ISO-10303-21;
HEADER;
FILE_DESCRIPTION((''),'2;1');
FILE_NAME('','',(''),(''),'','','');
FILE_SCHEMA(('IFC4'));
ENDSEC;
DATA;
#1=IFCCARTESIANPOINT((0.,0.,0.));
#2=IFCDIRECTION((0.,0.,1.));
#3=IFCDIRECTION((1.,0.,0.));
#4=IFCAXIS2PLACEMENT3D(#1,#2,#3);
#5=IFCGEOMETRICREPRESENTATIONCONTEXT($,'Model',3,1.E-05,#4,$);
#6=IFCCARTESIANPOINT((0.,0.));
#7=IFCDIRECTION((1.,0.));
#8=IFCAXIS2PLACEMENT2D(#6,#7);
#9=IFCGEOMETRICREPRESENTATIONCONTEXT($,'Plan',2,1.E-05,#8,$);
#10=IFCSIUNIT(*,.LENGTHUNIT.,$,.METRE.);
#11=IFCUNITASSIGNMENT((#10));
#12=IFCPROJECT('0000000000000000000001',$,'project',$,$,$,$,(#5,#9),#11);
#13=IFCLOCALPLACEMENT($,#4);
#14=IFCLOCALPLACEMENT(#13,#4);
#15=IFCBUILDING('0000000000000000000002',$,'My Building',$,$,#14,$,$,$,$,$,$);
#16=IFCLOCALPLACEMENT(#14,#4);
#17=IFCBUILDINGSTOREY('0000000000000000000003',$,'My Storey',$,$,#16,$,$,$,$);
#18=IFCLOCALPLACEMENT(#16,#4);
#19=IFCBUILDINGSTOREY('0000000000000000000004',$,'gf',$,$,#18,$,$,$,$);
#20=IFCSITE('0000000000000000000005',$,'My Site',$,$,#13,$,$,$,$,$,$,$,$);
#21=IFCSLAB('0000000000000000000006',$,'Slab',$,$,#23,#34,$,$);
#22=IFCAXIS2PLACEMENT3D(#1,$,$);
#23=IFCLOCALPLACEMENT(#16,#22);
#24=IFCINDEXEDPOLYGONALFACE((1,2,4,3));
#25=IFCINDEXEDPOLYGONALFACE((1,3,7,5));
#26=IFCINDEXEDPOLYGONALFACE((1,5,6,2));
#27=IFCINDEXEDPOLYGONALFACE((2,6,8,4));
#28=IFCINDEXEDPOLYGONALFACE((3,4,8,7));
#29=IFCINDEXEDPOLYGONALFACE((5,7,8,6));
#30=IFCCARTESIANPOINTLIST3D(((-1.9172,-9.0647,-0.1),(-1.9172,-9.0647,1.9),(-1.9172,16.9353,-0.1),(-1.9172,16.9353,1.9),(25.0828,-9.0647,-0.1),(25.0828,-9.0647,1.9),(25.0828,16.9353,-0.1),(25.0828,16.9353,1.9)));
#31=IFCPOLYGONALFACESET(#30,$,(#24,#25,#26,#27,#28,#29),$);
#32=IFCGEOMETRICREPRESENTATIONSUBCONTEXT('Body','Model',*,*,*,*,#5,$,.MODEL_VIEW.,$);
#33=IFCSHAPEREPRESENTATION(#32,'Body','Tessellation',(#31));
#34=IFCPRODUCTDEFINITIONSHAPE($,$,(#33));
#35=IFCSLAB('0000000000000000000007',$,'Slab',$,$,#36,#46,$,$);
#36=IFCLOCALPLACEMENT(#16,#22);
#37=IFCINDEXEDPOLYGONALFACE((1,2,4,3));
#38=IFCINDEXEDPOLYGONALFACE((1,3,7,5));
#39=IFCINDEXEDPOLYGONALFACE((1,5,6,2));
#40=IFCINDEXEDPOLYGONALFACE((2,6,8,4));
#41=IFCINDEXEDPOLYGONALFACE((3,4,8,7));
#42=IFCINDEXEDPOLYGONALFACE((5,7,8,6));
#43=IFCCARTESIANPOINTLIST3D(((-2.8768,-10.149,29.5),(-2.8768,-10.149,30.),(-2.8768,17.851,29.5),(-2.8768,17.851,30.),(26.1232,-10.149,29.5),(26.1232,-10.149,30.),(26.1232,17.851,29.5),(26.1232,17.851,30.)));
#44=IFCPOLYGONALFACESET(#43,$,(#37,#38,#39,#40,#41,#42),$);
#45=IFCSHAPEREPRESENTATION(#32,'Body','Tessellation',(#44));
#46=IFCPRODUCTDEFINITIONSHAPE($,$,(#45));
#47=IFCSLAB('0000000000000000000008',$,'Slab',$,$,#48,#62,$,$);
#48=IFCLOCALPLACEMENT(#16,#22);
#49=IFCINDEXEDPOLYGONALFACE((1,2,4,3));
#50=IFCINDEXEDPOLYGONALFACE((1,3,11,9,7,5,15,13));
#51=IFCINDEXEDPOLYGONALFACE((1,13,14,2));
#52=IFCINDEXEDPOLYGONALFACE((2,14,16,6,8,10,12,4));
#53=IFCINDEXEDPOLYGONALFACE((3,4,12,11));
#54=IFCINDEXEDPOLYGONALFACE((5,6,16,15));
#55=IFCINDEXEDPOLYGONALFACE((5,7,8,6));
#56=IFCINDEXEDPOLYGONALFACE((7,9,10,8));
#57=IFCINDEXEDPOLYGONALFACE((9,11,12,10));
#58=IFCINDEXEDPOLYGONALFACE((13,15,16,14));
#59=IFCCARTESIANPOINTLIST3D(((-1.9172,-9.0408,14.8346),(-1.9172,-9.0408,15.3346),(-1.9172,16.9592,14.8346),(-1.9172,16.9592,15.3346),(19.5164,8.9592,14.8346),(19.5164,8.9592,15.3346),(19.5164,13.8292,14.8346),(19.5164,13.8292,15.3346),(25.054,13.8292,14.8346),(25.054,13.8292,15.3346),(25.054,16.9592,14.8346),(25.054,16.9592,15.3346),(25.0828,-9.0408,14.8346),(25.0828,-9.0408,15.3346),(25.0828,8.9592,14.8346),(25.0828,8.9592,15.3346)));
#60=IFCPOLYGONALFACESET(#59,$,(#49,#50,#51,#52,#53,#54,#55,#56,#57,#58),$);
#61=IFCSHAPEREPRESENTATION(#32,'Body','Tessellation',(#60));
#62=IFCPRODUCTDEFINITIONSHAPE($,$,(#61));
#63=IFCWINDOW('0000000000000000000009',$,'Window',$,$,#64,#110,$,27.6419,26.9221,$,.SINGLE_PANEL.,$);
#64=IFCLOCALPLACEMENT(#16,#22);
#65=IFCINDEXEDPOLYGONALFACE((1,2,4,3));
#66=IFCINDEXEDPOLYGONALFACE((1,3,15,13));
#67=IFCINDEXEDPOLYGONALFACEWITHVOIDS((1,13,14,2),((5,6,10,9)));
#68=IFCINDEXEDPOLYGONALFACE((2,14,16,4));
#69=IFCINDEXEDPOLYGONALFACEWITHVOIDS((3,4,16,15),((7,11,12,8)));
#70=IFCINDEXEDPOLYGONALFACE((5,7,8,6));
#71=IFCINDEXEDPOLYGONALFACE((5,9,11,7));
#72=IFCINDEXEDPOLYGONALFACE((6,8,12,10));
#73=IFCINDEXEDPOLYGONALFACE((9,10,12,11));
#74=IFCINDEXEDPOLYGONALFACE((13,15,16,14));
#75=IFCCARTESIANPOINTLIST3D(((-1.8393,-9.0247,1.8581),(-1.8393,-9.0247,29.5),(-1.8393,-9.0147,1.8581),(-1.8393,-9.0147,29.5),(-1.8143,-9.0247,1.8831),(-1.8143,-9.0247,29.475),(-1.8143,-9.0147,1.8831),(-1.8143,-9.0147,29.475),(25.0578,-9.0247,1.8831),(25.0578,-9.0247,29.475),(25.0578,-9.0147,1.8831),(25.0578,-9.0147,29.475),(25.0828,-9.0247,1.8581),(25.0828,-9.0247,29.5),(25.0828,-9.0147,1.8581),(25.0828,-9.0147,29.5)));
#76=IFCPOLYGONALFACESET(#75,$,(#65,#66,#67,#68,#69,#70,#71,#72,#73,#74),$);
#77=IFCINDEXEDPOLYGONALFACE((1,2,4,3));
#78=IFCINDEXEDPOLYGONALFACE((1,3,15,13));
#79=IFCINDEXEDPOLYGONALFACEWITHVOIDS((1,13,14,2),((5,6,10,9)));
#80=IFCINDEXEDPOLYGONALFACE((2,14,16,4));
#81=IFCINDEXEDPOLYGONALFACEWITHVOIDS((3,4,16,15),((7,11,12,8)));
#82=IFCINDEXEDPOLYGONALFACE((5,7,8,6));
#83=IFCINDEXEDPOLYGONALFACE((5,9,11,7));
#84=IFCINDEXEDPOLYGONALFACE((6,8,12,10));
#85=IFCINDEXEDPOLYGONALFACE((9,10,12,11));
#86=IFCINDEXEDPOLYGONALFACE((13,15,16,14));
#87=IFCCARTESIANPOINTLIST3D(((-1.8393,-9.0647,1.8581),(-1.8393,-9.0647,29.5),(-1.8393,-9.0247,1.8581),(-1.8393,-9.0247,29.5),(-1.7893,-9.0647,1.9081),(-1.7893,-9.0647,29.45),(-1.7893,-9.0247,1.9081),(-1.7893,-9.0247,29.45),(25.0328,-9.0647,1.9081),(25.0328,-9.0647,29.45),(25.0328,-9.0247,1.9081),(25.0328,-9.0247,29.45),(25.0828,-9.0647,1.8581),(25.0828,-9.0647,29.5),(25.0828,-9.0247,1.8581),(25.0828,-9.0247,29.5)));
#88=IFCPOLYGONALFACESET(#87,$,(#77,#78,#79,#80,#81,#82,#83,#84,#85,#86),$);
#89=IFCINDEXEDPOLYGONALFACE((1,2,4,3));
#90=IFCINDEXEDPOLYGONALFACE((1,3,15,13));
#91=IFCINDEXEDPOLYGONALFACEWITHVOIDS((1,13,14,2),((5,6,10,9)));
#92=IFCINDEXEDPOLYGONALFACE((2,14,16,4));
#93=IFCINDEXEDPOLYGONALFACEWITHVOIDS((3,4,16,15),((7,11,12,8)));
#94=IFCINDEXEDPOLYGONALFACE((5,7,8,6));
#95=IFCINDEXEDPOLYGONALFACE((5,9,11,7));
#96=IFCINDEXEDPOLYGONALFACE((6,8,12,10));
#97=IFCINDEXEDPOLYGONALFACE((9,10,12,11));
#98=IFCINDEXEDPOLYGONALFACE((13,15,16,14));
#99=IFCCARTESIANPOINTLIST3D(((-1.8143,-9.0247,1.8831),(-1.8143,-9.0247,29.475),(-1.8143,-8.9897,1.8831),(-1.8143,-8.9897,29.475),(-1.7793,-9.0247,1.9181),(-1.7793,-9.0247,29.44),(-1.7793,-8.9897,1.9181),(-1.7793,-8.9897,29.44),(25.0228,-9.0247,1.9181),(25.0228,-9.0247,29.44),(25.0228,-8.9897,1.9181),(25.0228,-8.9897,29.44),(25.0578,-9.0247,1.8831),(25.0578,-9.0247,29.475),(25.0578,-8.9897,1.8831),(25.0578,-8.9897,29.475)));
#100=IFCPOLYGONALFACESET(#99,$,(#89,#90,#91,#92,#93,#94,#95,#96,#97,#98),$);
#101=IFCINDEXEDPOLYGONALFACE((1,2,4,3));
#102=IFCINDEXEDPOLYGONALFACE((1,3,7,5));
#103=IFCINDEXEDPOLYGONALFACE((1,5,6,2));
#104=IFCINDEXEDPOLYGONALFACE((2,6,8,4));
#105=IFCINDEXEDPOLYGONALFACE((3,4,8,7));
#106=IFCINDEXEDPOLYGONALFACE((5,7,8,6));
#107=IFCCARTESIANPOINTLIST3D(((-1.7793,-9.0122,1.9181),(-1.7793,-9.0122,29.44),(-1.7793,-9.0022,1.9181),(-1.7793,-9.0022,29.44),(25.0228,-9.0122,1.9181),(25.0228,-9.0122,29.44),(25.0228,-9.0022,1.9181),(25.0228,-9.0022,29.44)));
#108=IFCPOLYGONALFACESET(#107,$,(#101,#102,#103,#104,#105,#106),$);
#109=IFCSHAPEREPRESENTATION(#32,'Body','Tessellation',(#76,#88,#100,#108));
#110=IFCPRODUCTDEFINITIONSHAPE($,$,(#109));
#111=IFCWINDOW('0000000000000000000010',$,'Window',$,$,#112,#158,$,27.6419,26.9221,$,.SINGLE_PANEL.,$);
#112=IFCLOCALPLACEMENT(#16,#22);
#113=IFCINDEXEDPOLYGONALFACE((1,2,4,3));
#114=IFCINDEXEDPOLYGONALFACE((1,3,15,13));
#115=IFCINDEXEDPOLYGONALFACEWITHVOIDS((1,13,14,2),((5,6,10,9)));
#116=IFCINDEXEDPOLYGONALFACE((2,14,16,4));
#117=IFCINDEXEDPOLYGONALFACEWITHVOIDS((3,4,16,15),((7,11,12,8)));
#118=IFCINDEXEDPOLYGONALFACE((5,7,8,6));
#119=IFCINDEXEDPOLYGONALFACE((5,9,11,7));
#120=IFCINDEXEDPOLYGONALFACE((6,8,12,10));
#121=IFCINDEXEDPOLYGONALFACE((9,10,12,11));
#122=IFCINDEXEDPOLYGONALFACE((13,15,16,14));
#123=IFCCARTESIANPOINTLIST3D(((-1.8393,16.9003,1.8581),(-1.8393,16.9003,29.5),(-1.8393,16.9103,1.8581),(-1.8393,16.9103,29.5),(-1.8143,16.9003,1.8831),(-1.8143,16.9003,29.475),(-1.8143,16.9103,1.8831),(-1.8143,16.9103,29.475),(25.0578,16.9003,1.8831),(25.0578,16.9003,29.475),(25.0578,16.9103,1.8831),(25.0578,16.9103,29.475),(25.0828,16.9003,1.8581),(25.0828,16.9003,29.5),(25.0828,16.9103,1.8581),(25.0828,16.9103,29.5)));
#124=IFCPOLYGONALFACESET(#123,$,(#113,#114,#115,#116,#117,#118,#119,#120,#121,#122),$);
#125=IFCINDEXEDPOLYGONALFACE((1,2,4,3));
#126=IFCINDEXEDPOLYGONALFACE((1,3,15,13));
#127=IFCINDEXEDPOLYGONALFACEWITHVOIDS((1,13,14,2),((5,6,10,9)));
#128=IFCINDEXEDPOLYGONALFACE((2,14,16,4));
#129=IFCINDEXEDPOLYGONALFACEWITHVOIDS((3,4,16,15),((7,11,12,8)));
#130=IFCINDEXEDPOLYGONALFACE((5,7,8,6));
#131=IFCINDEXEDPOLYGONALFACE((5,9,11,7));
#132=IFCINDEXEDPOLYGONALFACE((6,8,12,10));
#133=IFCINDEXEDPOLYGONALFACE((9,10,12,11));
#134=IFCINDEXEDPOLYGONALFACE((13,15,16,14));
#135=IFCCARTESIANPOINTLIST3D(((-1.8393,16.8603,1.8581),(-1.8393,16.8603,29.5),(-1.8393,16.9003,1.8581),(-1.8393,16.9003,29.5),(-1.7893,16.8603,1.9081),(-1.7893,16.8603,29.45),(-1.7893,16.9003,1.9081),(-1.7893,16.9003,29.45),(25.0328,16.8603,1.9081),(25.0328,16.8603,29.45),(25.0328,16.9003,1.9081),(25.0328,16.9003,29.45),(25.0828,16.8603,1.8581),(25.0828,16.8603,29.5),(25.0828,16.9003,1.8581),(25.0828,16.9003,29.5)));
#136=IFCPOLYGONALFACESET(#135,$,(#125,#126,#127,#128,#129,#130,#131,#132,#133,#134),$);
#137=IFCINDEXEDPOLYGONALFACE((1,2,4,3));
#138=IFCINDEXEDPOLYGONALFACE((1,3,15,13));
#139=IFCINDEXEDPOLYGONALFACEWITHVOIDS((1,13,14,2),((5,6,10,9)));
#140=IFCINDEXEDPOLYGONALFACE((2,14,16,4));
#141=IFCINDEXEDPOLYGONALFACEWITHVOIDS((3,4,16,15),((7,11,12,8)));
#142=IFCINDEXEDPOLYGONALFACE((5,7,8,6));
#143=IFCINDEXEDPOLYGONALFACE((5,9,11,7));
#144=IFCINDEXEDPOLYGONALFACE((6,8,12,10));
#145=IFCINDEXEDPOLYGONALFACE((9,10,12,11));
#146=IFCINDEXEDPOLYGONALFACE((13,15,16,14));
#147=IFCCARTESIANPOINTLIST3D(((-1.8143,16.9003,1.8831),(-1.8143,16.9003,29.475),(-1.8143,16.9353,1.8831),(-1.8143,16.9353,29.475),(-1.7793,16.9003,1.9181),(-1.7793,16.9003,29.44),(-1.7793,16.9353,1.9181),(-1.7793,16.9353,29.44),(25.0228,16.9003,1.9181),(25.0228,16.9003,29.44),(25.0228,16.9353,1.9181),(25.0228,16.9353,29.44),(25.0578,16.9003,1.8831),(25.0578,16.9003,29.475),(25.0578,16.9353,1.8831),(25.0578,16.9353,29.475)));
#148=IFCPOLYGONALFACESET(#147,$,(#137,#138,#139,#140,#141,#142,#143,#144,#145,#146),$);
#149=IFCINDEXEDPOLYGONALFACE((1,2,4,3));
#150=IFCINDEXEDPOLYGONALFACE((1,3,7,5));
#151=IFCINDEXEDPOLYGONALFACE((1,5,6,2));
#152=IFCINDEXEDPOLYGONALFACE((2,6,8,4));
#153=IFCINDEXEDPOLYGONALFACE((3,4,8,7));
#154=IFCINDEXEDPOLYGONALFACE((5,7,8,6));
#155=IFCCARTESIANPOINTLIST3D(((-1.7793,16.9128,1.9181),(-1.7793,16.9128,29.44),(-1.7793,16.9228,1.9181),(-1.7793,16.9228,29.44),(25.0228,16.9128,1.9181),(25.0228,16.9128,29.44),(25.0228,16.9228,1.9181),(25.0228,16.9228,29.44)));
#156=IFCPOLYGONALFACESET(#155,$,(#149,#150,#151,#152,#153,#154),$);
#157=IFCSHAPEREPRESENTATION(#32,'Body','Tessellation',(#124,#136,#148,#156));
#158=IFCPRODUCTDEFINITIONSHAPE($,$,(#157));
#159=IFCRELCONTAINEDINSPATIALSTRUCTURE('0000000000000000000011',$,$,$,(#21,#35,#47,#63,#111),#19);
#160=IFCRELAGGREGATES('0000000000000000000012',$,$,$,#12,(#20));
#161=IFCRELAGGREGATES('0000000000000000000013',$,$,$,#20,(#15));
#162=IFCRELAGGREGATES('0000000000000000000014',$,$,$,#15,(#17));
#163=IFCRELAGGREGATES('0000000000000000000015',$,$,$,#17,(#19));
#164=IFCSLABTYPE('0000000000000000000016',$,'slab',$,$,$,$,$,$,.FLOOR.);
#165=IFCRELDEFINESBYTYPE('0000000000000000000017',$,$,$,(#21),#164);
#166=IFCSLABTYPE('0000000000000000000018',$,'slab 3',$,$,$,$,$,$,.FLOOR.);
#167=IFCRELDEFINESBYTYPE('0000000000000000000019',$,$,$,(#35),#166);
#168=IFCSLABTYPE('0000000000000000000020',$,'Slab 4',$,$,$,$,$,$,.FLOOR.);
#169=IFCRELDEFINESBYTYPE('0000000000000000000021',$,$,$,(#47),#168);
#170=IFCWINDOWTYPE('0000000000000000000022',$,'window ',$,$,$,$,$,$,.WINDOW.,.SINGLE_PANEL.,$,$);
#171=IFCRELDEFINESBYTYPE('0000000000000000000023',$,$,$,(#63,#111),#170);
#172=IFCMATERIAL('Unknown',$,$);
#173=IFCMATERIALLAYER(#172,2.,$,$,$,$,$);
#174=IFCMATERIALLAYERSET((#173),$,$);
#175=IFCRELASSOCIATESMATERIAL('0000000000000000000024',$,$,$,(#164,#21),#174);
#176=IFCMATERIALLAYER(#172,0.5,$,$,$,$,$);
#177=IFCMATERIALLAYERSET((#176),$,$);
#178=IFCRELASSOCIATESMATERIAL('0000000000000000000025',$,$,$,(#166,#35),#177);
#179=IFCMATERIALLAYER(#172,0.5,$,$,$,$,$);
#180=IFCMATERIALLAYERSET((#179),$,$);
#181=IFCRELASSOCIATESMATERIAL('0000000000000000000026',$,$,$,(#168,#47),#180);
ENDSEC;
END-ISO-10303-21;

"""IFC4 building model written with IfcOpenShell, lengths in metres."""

from ifc_helpers import new_model, entity, si_unit, frame, origin_with_axes, origin_2d_with_axis, place, context, subcontext, project, spatial, line, indexed_curve, outline, extrude, shape, source, transform, mapped, material, layer, layer_set, layer_usage, type_object, type_shapes, element, save


model = new_model("IFC4")

# Units and contexts
model_context = context("Model", 3, precision=1e-05, world=origin_with_axes())
plan_context = context("Plan", 2, precision=1e-05, world=origin_2d_with_axis())
body_context_1 = subcontext(model_context, "Body", "Model", "MODEL_VIEW")
body_context_2 = subcontext(plan_context, "Body", "Plan", "PLAN_VIEW")
ifc_project = project(units=[si_unit("LENGTHUNIT", "METRE")], contexts=[model_context, plan_context])

# Site, building, storeys
site_placement = place(None, origin_with_axes())
site = spatial("IfcSite", under=ifc_project, at=site_placement, Name="My Site")
building_placement = place(site_placement, origin_with_axes())
building = spatial("IfcBuilding", under=site, at=building_placement, Name="My Building")
storey_1_placement = place(building_placement, origin_with_axes())
storey_1 = spatial("IfcBuildingStorey", under=building, at=storey_1_placement, Name="My Storey")
storey_2_placement = place(storey_1_placement, origin_with_axes())
storey_2 = spatial("IfcBuildingStorey", under=storey_1, at=storey_2_placement, Name="gf")

# Slabs
ifc_material = material(Name="Unknown")
ifc_layer_1 = layer(ifc_material, 2.0)
ifc_layer_set_1 = layer_set([ifc_layer_1])
ifc_layer_usage_1 = layer_usage(ifc_layer_set_1, "AXIS3", "POSITIVE", -0.1)
slab_type_1 = type_object("IfcSlabType", Name="slab", PredefinedType="FLOOR", material=ifc_layer_set_1)
slab_1_placement = place(storey_2_placement, frame((-1.9172, 16.9353, 0.0), z_axis=(0.0, 0.0, 1.0), x_axis=(1.0, 0.0, 0.0)))
element("IfcSlab", 1, at=slab_1_placement, inside=storey_2, type_object=slab_type_1, material=ifc_layer_usage_1, Name="Slab", context=body_context_1, shape_type="SweptSolid", body=[
    extrude(outline(indexed_curve([(0.0, 0.0), (0.0, -26.0), (27.0, -26.0), (27.0, 0.0), (0.0, 0.0)])), frame((0.0, 0.0, -0.1), z_axis=(0.0, 0.0, 1.0), x_axis=(1.0, 0.0, 0.0)), (0.0, 0.0, 1.0), 2.0),
])
ifc_layer_2 = layer(ifc_material, 0.5)
ifc_layer_set_2 = layer_set([ifc_layer_2])
ifc_layer_usage_2 = layer_usage(ifc_layer_set_2, "AXIS3", "POSITIVE", -0.5)
slab_type_2 = type_object("IfcSlabType", Name="slab 3", PredefinedType="FLOOR", material=ifc_layer_set_2)
slab_2_placement = place(storey_2_placement, frame((-2.8768, 17.851, 30.0), z_axis=(0.0, 0.0, 1.0), x_axis=(1.0, 0.0, 0.0)))
element("IfcSlab", 2, at=slab_2_placement, inside=storey_2, type_object=slab_type_2, material=ifc_layer_usage_2, Name="Slab", context=body_context_1, shape_type="SweptSolid", body=[
    extrude(outline(indexed_curve([(0.0, 0.0), (0.0, -28.0), (29.0, -28.0), (29.0, 0.0), (0.0, 0.0)])), frame((0.0, 0.0, -0.5), z_axis=(0.0, 0.0, 1.0), x_axis=(1.0, 0.0, 0.0)), (0.0, 0.0, 1.0), 0.5),
])
ifc_layer_3 = layer(ifc_material, 0.5)
ifc_layer_set_3 = layer_set([ifc_layer_3])
ifc_layer_usage_3 = layer_usage(ifc_layer_set_3, "AXIS3", "POSITIVE", -0.5)
slab_type_3 = type_object("IfcSlabType", Name="Slab 4", PredefinedType="FLOOR", material=ifc_layer_set_3)
slab_3_placement = place(storey_2_placement, frame((-1.9172, 16.9592, 15.3346), z_axis=(0.0, 0.0, 1.0), x_axis=(1.0, 0.0, 0.0)))
element("IfcSlab", 3, at=slab_3_placement, inside=storey_2, type_object=slab_type_3, material=ifc_layer_usage_3, Name="Slab", context=body_context_1, shape_type="SweptSolid", body=[
    extrude(outline(indexed_curve([(0.0, 0.0), (0.0, -26.0), (27.0, -26.0), (27.0, -8.0), (21.4336, -8.0), (21.4336, -3.13), (26.9711, -3.13), (26.9711, 0.0), (0.0, 0.0)])), frame((0.0, 0.0, -0.5), z_axis=(0.0, 0.0, 1.0), x_axis=(1.0, 0.0, 0.0)), (0.0, 0.0, 1.0), 0.5),
])

# Windows
window_type_1 = type_object("IfcWindowType", Name="window ", PartitioningType="SINGLE_PANEL", PredefinedType="WINDOW")
shared_shape_1 = source(origin_with_axes(), body_context_1, "Body", "SweptSolid", [
    extrude(outline(indexed_curve([(0.0, 0.0), (26.9221, 0.0), (26.9221, 27.6419), (0.0, 27.6419)], segments=[line(1, 2, 3, 4, 1)]), holes=[indexed_curve([(0.025, 0.025), (26.8971, 0.025), (26.8971, 27.6169), (0.025, 27.6169)], segments=[line(1, 2, 3, 4, 1)])]), frame((0.0, 0.09, 0.0), z_axis=(0.0, -1.0, 0.0), x_axis=(1.0, 0.0, 0.0)), (0.0, 0.0, -1.0), 0.01),
    extrude(outline(indexed_curve([(0.0, 0.0), (26.9221, 0.0), (26.9221, 27.6419), (0.0, 27.6419)], segments=[line(1, 2, 3, 4, 1)]), holes=[indexed_curve([(0.05, 0.05), (26.8721, 0.05), (26.8721, 27.5919), (0.05, 27.5919)], segments=[line(1, 2, 3, 4, 1)])]), frame((0.0, 0.05, 0.0), z_axis=(0.0, -1.0, 0.0), x_axis=(1.0, 0.0, 0.0)), (0.0, 0.0, -1.0), 0.04),
    extrude(outline(indexed_curve([(0.0, 0.0), (26.8721, 0.0), (26.8721, 27.5919), (0.0, 27.5919)], segments=[line(1, 2, 3, 4, 1)]), holes=[indexed_curve([(0.035, 0.035), (26.8371, 0.035), (26.8371, 27.5569), (0.035, 27.5569)], segments=[line(1, 2, 3, 4, 1)])]), frame((0.025, 0.09, 0.025), z_axis=(0.0, -1.0, 0.0), x_axis=(1.0, 0.0, 0.0)), (0.0, 0.0, -1.0), 0.035),
    extrude(outline(indexed_curve([(0.035, 0.035), (26.8371, 0.035), (26.8371, 27.5569), (0.035, 27.5569)], segments=[line(1, 2, 3, 4, 1)])), frame((0.025, 0.1025, 0.025), z_axis=(0.0, -1.0, 0.0), x_axis=(1.0, 0.0, 0.0)), (0.0, 0.0, -1.0), 0.01),
])
shared_shape_2 = source(origin_with_axes(), body_context_2, "Body", "Curve2D", [
    entity("IfcIndexedPolyCurve", entity("IfcCartesianPointList2D", [[0.05, 0.05], [26.8721, 0.05]])),
    entity("IfcIndexedPolyCurve", entity("IfcCartesianPointList2D", [[0.0, 0.1], [0.025, 0.1], [0.025, 0.09], [0.05, 0.09], [0.05, 0.05], [0.0, 0.05]]), [entity("IfcLineIndex", [1, 2, 3, 4, 5, 6, 1])]),
    entity("IfcIndexedPolyCurve", entity("IfcCartesianPointList2D", [[26.9221, 0.1], [26.8971, 0.1], [26.8971, 0.09], [26.8721, 0.09], [26.8721, 0.05], [26.9221, 0.05]]), [entity("IfcLineIndex", [1, 2, 3, 4, 5, 6, 1])]),
    entity("IfcIndexedPolyCurve", entity("IfcCartesianPointList2D", [[0.025, 0.09], [0.06, 0.09], [0.06, 0.125], [0.025, 0.125]]), [entity("IfcLineIndex", [1, 2, 3, 4, 1])]),
    entity("IfcIndexedPolyCurve", entity("IfcCartesianPointList2D", [[26.8971, 0.09], [26.8621, 0.09], [26.8621, 0.125], [26.8971, 0.125]]), [entity("IfcLineIndex", [1, 2, 3, 4, 1])]),
    entity("IfcIndexedPolyCurve", entity("IfcCartesianPointList2D", [[0.06, 0.09], [26.8621, 0.09]])),
    entity("IfcIndexedPolyCurve", entity("IfcCartesianPointList2D", [[0.06, 0.125], [26.8621, 0.125]])),
    entity("IfcIndexedPolyCurve", entity("IfcCartesianPointList2D", [[0.06, 0.1075], [26.8621, 0.1075]])),
])
type_shapes(window_type_1, [shared_shape_1, shared_shape_2])
for number, where, z_axis, x_axis, name in (
    (4, (-1.8393, -9.1147, 1.8581), (0.0, 0.0, 1.0), (1.0, 0.0, 0.0), "Window"),
    (5, (-1.8393, 16.8103, 1.8581), (0.0, 0.0, 1.0), (1.0, 0.0, 0.0), "Window"),
):
    element("IfcWindow", number, at=place(storey_2_placement, frame(where, z_axis=z_axis, x_axis=x_axis)), inside=storey_2, type_object=window_type_1, Name=name, OverallHeight=27.6419, OverallWidth=26.9221, PartitioningType="SINGLE_PANEL", shapes=[
        shape(body_context_1, "Body", "MappedRepresentation", [mapped(shared_shape_1, transform((0.0, 0.0, 0.0), x_axis=(1.0, 0.0, 0.0), y_axis=(0.0, 1.0, 0.0), z_axis=(0.0, 0.0, 1.0), scale=1.0))]),
        shape(body_context_2, "Body", "MappedRepresentation", [mapped(shared_shape_2, transform((0.0, 0.0, 0.0), x_axis=(1.0, 0.0, 0.0), y_axis=(0.0, 1.0, 0.0), z_axis=(0.0, 0.0, 1.0), scale=1.0))]),
    ])

save(model, "model.ifc")
